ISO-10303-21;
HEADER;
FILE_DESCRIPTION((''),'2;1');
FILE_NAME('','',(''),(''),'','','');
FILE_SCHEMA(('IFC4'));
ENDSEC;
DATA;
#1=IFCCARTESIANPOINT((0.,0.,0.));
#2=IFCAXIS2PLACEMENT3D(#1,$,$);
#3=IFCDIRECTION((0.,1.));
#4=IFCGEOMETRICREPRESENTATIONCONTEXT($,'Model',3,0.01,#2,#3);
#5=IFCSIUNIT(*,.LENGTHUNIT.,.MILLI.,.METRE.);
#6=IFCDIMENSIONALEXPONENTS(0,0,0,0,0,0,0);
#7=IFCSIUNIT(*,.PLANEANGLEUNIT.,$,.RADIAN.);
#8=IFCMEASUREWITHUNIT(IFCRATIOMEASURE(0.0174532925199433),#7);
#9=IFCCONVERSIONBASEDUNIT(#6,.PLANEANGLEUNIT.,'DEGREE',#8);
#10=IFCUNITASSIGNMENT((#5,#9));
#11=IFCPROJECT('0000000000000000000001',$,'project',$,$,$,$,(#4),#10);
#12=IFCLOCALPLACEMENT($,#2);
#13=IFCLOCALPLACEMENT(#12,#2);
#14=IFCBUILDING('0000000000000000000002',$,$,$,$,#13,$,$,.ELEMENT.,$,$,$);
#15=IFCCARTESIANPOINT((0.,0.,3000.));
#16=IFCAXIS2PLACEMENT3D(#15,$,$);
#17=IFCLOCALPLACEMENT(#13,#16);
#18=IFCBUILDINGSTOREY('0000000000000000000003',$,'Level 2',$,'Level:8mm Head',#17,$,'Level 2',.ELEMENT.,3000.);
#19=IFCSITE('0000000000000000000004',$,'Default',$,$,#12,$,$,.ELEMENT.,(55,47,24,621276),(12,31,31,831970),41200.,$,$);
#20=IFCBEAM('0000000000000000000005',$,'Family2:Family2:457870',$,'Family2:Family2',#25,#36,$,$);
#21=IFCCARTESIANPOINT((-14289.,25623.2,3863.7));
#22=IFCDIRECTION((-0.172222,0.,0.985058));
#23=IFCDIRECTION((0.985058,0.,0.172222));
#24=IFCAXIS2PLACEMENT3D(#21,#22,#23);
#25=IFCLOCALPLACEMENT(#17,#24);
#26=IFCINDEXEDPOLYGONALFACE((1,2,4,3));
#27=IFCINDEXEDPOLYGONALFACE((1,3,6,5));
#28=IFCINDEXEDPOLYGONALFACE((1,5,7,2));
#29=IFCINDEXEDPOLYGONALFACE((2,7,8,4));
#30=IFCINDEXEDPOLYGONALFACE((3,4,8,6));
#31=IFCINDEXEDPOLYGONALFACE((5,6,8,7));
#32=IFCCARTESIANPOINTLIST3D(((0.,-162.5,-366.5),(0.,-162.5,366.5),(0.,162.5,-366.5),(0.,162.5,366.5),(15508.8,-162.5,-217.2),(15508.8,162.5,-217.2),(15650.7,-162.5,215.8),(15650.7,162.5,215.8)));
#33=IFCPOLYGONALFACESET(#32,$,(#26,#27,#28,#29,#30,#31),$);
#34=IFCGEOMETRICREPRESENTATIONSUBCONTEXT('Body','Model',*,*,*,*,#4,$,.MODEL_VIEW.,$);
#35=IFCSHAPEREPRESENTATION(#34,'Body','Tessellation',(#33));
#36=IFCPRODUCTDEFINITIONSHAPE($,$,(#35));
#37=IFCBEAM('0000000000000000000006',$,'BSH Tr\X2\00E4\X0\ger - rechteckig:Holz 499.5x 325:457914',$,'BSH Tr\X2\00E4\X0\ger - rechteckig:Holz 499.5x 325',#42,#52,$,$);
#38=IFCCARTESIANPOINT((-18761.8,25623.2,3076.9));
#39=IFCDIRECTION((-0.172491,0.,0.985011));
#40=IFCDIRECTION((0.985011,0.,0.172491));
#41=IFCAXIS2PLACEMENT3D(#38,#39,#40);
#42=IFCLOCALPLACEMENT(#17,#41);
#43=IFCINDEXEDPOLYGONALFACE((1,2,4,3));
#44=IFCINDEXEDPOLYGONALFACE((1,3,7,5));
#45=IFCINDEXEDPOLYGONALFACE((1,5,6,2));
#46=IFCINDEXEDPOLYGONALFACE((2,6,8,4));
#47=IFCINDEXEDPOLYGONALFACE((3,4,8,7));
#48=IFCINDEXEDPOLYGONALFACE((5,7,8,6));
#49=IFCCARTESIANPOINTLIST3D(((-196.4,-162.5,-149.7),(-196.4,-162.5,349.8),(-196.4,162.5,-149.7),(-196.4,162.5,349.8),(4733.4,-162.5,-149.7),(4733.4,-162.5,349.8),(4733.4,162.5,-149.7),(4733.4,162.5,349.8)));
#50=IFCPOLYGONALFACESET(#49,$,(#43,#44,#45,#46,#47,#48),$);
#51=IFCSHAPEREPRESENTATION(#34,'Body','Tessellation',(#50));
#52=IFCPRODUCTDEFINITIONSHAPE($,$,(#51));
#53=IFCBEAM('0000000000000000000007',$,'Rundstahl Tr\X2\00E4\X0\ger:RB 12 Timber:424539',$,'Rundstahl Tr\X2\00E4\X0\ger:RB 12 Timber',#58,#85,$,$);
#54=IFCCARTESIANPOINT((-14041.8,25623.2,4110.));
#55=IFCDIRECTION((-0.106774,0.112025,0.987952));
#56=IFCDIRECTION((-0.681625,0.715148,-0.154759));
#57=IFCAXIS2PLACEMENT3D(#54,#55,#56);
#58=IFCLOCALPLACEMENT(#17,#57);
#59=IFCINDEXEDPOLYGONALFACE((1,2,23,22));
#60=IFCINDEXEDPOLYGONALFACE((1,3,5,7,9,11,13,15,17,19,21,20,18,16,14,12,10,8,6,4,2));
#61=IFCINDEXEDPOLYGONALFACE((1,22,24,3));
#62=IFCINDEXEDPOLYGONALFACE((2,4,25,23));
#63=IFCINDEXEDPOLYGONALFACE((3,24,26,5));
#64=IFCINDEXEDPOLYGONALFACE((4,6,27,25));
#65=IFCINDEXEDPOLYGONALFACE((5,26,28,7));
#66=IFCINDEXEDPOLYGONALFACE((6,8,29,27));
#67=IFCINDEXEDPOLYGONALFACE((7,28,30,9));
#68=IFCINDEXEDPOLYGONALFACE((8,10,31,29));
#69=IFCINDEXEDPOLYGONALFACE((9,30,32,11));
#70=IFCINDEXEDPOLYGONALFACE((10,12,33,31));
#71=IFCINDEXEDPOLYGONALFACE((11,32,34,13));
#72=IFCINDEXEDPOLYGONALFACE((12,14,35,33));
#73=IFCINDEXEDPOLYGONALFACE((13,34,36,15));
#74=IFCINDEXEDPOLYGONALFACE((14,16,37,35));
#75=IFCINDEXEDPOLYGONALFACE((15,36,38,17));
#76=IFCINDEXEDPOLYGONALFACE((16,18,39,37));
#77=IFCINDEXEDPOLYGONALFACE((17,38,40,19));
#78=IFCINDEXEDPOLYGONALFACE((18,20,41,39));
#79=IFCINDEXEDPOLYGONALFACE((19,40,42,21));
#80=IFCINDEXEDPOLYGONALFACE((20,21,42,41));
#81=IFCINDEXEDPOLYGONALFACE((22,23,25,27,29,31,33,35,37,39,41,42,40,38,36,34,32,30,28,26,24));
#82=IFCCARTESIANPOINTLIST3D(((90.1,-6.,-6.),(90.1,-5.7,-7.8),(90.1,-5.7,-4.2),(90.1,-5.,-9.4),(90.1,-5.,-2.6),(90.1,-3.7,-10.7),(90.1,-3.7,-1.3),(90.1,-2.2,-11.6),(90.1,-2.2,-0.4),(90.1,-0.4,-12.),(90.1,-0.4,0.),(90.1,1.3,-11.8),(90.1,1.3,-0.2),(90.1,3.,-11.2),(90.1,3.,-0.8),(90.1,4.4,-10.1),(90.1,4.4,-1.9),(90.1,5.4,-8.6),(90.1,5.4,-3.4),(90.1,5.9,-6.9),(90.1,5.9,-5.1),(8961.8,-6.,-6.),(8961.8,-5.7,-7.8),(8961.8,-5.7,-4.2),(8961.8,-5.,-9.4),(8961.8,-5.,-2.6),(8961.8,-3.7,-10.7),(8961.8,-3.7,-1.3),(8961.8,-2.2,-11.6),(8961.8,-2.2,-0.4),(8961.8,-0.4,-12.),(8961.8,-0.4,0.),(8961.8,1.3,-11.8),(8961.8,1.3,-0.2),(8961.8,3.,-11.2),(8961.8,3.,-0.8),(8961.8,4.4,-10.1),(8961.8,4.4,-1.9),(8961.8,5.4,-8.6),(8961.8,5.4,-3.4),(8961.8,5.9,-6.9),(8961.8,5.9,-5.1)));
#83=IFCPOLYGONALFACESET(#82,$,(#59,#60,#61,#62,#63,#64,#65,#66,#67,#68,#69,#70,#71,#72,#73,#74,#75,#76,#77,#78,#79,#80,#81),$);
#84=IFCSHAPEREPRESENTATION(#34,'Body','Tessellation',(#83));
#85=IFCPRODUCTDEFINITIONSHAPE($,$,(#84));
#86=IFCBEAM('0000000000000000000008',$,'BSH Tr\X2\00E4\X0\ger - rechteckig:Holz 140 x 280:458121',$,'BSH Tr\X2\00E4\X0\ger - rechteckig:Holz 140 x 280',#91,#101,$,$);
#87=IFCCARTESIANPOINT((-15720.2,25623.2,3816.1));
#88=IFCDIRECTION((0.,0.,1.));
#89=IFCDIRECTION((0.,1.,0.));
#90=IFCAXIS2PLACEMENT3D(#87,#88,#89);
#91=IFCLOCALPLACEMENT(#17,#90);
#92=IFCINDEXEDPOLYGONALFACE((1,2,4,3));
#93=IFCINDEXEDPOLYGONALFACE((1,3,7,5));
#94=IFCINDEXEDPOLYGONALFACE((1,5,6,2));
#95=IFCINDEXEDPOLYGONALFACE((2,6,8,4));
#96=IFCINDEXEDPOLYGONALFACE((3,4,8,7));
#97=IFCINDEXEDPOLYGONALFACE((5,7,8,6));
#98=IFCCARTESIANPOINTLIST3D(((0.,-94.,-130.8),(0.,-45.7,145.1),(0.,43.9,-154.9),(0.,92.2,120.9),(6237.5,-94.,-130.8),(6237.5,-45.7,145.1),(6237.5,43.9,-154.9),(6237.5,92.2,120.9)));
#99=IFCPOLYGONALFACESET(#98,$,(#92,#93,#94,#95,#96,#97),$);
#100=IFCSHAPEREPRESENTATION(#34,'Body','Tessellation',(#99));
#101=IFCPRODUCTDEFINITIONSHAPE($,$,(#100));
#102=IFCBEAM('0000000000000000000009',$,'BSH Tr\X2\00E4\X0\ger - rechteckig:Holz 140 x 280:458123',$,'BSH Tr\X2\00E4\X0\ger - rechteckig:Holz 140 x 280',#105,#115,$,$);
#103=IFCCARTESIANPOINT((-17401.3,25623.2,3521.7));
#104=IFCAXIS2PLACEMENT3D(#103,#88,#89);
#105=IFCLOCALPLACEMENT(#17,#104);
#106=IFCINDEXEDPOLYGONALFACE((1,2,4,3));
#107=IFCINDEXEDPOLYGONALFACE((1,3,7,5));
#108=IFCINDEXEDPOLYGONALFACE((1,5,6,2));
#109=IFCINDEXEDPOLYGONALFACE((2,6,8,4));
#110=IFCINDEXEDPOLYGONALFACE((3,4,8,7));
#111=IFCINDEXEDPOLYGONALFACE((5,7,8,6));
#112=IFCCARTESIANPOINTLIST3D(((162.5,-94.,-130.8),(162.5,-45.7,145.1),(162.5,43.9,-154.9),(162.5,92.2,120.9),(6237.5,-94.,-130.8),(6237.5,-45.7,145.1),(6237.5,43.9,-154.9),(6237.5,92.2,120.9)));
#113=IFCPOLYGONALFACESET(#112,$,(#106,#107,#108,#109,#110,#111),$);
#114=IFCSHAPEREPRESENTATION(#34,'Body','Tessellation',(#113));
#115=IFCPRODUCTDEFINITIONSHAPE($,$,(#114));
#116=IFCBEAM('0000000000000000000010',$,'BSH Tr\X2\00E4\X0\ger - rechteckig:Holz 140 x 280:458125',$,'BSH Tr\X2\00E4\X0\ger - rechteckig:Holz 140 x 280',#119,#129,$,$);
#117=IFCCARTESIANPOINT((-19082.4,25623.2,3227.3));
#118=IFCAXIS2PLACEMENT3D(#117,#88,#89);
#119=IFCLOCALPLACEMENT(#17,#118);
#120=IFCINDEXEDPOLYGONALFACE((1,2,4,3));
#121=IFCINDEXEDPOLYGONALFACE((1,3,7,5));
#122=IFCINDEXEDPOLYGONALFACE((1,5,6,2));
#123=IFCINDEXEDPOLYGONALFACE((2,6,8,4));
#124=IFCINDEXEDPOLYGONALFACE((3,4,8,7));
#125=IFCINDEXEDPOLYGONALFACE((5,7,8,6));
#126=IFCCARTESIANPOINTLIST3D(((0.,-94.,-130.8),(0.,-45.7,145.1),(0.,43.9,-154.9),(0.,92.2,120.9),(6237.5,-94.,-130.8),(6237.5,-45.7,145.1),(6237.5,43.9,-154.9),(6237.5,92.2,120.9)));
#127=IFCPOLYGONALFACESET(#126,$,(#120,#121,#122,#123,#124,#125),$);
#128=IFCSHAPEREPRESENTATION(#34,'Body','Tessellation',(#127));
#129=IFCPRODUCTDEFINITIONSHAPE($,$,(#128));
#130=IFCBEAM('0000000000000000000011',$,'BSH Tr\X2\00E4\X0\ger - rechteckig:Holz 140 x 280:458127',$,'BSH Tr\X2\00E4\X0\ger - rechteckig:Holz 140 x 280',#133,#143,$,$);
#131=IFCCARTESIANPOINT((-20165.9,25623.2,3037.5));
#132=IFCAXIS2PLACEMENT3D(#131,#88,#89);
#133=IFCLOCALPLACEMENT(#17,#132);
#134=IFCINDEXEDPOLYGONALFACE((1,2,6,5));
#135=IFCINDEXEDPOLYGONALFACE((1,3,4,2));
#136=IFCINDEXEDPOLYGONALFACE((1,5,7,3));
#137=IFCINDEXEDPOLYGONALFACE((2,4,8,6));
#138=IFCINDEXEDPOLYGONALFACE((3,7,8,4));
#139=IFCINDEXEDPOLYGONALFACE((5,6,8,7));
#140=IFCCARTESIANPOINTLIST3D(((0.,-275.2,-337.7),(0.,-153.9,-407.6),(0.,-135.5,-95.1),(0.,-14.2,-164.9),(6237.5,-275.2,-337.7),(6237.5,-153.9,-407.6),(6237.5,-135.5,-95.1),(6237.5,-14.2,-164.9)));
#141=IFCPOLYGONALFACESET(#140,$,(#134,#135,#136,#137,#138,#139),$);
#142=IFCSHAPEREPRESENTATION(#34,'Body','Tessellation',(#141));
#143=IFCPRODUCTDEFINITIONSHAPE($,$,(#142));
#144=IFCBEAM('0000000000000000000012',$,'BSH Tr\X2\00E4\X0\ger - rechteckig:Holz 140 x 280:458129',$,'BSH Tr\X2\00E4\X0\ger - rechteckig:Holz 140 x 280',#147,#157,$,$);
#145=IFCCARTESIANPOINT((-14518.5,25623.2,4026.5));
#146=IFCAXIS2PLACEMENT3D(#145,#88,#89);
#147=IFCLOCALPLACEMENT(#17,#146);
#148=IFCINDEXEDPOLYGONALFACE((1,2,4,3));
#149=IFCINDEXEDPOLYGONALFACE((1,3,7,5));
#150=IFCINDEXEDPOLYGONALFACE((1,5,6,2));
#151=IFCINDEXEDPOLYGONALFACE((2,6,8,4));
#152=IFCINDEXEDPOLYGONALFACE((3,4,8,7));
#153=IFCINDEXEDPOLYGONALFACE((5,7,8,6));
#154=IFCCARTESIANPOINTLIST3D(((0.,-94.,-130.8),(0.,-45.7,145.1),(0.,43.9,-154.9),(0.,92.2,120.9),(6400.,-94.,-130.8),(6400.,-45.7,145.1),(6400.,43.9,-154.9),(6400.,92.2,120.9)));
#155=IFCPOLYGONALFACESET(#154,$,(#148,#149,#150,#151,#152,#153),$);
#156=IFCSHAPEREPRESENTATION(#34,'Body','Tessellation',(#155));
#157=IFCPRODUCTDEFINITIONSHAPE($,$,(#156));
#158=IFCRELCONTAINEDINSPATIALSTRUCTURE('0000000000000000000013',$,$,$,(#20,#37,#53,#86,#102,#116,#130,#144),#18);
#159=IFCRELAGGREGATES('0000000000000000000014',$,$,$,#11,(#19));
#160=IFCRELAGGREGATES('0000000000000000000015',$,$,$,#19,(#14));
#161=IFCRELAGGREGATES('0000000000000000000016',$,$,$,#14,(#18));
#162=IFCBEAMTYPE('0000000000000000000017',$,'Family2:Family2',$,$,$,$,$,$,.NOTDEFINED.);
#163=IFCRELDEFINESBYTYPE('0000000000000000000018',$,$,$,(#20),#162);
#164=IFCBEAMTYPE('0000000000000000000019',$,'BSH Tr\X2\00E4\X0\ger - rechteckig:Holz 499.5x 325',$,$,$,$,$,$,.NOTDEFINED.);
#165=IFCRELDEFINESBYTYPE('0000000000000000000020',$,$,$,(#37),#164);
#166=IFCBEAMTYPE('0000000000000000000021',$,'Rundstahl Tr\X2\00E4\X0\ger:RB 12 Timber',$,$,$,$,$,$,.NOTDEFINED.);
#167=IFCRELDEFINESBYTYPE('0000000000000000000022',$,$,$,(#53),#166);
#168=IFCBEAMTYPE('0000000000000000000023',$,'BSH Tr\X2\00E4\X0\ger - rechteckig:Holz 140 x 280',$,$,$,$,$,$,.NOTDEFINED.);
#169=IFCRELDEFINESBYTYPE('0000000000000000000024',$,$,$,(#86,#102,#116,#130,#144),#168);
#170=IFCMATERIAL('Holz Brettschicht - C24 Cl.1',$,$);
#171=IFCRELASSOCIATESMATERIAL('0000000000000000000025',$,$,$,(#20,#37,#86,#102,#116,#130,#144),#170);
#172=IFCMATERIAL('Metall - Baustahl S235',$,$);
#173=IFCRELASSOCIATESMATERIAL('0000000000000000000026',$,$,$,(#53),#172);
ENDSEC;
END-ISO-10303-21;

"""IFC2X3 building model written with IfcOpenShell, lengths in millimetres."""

from ifc_helpers import new_model, entity, si_unit, converted_unit, direction, frame, frame_2d, origin, origin_2d_with_axis, place, context, subcontext, project, spatial, polyline, rectangle, circle, extrude, clip, bounded_halfspace, material, type_object, element, save


model = new_model("IFC2X3")

# Units and contexts
model_context = context("Model", 3, precision=0.01, world=origin(), true_north=direction((0.0, 1.0)))
body_context = subcontext(model_context, "Body", "Model", "MODEL_VIEW")
ifc_project = project(units=[si_unit("LENGTHUNIT", "METRE", prefix="MILLI"), converted_unit("PLANEANGLEUNIT", "DEGREE", entity("IfcRatioMeasure", 0.0174532925199433), si_unit("PLANEANGLEUNIT", "RADIAN"), dimensions=[0, 0, 0, 0, 0, 0, 0])], contexts=[model_context])

# Site, building, storey
site_placement = place(None, origin())
site = spatial("IfcSite", under=ifc_project, at=site_placement, Name="Default", CompositionType="ELEMENT", RefLatitude=(55, 47, 24, 621276), RefLongitude=(12, 31, 31, 831970), RefElevation=41200.0)
building_placement = place(site_placement, origin())
building = spatial("IfcBuilding", under=site, at=building_placement, CompositionType="ELEMENT")
storey_placement = place(building_placement, frame((0.0, 0.0, 3000.0)))
storey = spatial("IfcBuildingStorey", under=building, at=storey_placement, Name="Level 2", ObjectType="Level:8mm Head", LongName="Level 2", CompositionType="ELEMENT", Elevation=3000.0)

# Beams
ifc_material_1 = material(Name="Holz Brettschicht - C24 Cl.1")
beam_type_1 = type_object("IfcBeamType", Name="Family2:Family2", PredefinedType="NOTDEFINED")
beam_1_placement = place(storey_placement, frame((-14289.0, 25623.2, 3863.7), z_axis=(-0.172222, 0.0, 0.985058), x_axis=(0.985058, 0.0, 0.172222)))
element("IfcBeam", 1, at=beam_1_placement, inside=storey, type_object=beam_type_1, material=ifc_material_1, Name="Family2:Family2:457870", ObjectType="Family2:Family2", context=body_context, shape_type="Clipping", body=[
    clip(clip(clip(extrude(rectangle(XDim=733.0, YDim=325.0, at=frame_2d((0.0, 0.0), x_axis=(0.0, 1.0))), frame((0.0, 0.0, 0.0), z_axis=(1.0, 0.0, 0.0), x_axis=(0.0, 1.0, 0.0)), (0.0, 0.0, 1.0), 15650.7), bounded_halfspace(frame((0.0, 0.0, -366.5), z_axis=(0.009627, 0.0, -0.999954), x_axis=(0.0, 1.0, 0.0)), False, frame((0.0, 0.0, 0.0), z_axis=(1.0, 0.0, 0.0), x_axis=(0.0, 1.0, 0.0)), polyline([(-162.5, -366.5), (162.5, -366.5), (162.5, -217.2), (-162.5, -217.2), (-162.5, -366.5)]))), bounded_halfspace(frame((15700.1, 0.0, 366.5), z_axis=(0.95028, 0.0, -0.311395), x_axis=(0.311395, 0.0, 0.95028)), False, frame((0.0, 0.0, 0.0), z_axis=(1.0, 0.0, 0.0), x_axis=(0.0, 1.0, 0.0)), polyline([(-162.5, 215.8), (-162.5, -217.2), (162.5, -217.2), (162.5, 215.8), (-162.5, 215.8)]))), bounded_halfspace(frame((0.0, 0.0, 366.5), z_axis=(0.009627, 0.0, 0.999954), x_axis=(0.0, -1.0, 0.0)), False, frame((0.0, 0.0, 0.0), z_axis=(1.0, 0.0, 0.0), x_axis=(0.0, 1.0, 0.0)), polyline([(162.5, 366.5), (-162.5, 366.5), (-162.5, 215.8), (162.5, 215.8), (162.5, 366.5)]))),
])
beam_type_2 = type_object("IfcBeamType", Name="BSH Träger - rechteckig:Holz 499.5x 325", PredefinedType="NOTDEFINED")
beam_2_placement = place(storey_placement, frame((-18761.8, 25623.2, 3076.9), z_axis=(-0.172491, 0.0, 0.985011), x_axis=(0.985011, 0.0, 0.172491)))
element("IfcBeam", 2, at=beam_2_placement, inside=storey, type_object=beam_type_2, material=ifc_material_1, Name="BSH Träger - rechteckig:Holz 499.5x 325:457914", ObjectType="BSH Träger - rechteckig:Holz 499.5x 325", context=body_context, shape_type="SweptSolid", body=[
    extrude(rectangle(XDim=499.5, YDim=325.0, at=frame_2d((0.0, 0.0), x_axis=(1.0, 0.0))), frame((-196.4, 0.0, 100.0), z_axis=(1.0, 0.0, 0.0), x_axis=(0.0, 0.0, -1.0)), (0.0, 0.0, 1.0), 4929.8),
])
ifc_material_2 = material(Name="Metall - Baustahl S235")
beam_type_3 = type_object("IfcBeamType", Name="Rundstahl Träger:RB 12 Timber", PredefinedType="NOTDEFINED")
beam_3_placement = place(storey_placement, frame((-14041.8, 25623.2, 4110.0), z_axis=(-0.106774, 0.112025, 0.987952), x_axis=(-0.681625, 0.715148, -0.154759)))
element("IfcBeam", 3, at=beam_3_placement, inside=storey, type_object=beam_type_3, material=ifc_material_2, Name="Rundstahl Träger:RB 12 Timber:424539", ObjectType="Rundstahl Träger:RB 12 Timber", context=body_context, shape_type="SweptSolid", body=[
    extrude(circle(Radius=6.0, at=origin_2d_with_axis()), frame((90.1, 0.0, -6.0), z_axis=(1.0, 0.0, 0.0), x_axis=(0.0, -1.0, 0.0)), (0.0, 0.0, 1.0), 8871.7),
])
beam_type_4 = type_object("IfcBeamType", Name="BSH Träger - rechteckig:Holz 140 x 280", PredefinedType="NOTDEFINED")
beam_4_placement = place(storey_placement, frame((-15720.2, 25623.2, 3816.1), z_axis=(0.0, 0.0, 1.0), x_axis=(0.0, 1.0, 0.0)))
element("IfcBeam", 4, at=beam_4_placement, inside=storey, type_object=beam_type_4, material=ifc_material_1, Name="BSH Träger - rechteckig:Holz 140 x 280:458121", ObjectType="BSH Träger - rechteckig:Holz 140 x 280", context=body_context, shape_type="SweptSolid", body=[
    extrude(rectangle(XDim=280.0, YDim=140.0, at=origin_2d_with_axis()), frame((0.0, -0.9, -4.9), z_axis=(1.0, 0.0, 0.0), x_axis=(0.0, 0.172491, 0.985011)), (0.0, 0.0, 1.0), 6237.5),
])
beam_5_placement = place(storey_placement, frame((-17401.3, 25623.2, 3521.7), z_axis=(0.0, 0.0, 1.0), x_axis=(0.0, 1.0, 0.0)))
element("IfcBeam", 5, at=beam_5_placement, inside=storey, type_object=beam_type_4, material=ifc_material_1, Name="BSH Träger - rechteckig:Holz 140 x 280:458123", ObjectType="BSH Träger - rechteckig:Holz 140 x 280", context=body_context, shape_type="SweptSolid", body=[
    extrude(rectangle(XDim=280.0, YDim=140.0, at=origin_2d_with_axis()), frame((162.5, -0.9, -4.9), z_axis=(1.0, 0.0, 0.0), x_axis=(0.0, 0.172491, 0.985011)), (0.0, 0.0, 1.0), 6075.0),
])
beam_6_placement = place(storey_placement, frame((-19082.4, 25623.2, 3227.3), z_axis=(0.0, 0.0, 1.0), x_axis=(0.0, 1.0, 0.0)))
element("IfcBeam", 6, at=beam_6_placement, inside=storey, type_object=beam_type_4, material=ifc_material_1, Name="BSH Träger - rechteckig:Holz 140 x 280:458125", ObjectType="BSH Träger - rechteckig:Holz 140 x 280", context=body_context, shape_type="SweptSolid", body=[
    extrude(rectangle(XDim=280.0, YDim=140.0, at=origin_2d_with_axis()), frame((0.0, -0.9, -4.9), z_axis=(1.0, 0.0, 0.0), x_axis=(0.0, 0.172491, 0.985011)), (0.0, 0.0, 1.0), 6237.5),
])
beam_7_placement = place(storey_placement, frame((-20165.9, 25623.2, 3037.5), z_axis=(0.0, 0.0, 1.0), x_axis=(0.0, 1.0, 0.0)))
element("IfcBeam", 7, at=beam_7_placement, inside=storey, type_object=beam_type_4, material=ifc_material_1, Name="BSH Träger - rechteckig:Holz 140 x 280:458127", ObjectType="BSH Träger - rechteckig:Holz 140 x 280", context=body_context, shape_type="SweptSolid", body=[
    extrude(rectangle(XDim=280.0, YDim=140.0, at=origin_2d_with_axis()), frame((0.0, -144.7, -251.3), z_axis=(1.0, 0.0, 0.0), x_axis=(0.0, 0.498982, 0.866612)), (0.0, 0.0, 1.0), 6237.5),
])
beam_8_placement = place(storey_placement, frame((-14518.5, 25623.2, 4026.5), z_axis=(0.0, 0.0, 1.0), x_axis=(0.0, 1.0, 0.0)))
element("IfcBeam", 8, at=beam_8_placement, inside=storey, type_object=beam_type_4, material=ifc_material_1, Name="BSH Träger - rechteckig:Holz 140 x 280:458129", ObjectType="BSH Träger - rechteckig:Holz 140 x 280", context=body_context, shape_type="SweptSolid", body=[
    extrude(rectangle(XDim=280.0, YDim=140.0, at=origin_2d_with_axis()), frame((0.0, -0.9, -4.9), z_axis=(1.0, 0.0, 0.0), x_axis=(0.0, 0.172491, 0.985011)), (0.0, 0.0, 1.0), 6400.0),
])

save(model, "model.ifc")
